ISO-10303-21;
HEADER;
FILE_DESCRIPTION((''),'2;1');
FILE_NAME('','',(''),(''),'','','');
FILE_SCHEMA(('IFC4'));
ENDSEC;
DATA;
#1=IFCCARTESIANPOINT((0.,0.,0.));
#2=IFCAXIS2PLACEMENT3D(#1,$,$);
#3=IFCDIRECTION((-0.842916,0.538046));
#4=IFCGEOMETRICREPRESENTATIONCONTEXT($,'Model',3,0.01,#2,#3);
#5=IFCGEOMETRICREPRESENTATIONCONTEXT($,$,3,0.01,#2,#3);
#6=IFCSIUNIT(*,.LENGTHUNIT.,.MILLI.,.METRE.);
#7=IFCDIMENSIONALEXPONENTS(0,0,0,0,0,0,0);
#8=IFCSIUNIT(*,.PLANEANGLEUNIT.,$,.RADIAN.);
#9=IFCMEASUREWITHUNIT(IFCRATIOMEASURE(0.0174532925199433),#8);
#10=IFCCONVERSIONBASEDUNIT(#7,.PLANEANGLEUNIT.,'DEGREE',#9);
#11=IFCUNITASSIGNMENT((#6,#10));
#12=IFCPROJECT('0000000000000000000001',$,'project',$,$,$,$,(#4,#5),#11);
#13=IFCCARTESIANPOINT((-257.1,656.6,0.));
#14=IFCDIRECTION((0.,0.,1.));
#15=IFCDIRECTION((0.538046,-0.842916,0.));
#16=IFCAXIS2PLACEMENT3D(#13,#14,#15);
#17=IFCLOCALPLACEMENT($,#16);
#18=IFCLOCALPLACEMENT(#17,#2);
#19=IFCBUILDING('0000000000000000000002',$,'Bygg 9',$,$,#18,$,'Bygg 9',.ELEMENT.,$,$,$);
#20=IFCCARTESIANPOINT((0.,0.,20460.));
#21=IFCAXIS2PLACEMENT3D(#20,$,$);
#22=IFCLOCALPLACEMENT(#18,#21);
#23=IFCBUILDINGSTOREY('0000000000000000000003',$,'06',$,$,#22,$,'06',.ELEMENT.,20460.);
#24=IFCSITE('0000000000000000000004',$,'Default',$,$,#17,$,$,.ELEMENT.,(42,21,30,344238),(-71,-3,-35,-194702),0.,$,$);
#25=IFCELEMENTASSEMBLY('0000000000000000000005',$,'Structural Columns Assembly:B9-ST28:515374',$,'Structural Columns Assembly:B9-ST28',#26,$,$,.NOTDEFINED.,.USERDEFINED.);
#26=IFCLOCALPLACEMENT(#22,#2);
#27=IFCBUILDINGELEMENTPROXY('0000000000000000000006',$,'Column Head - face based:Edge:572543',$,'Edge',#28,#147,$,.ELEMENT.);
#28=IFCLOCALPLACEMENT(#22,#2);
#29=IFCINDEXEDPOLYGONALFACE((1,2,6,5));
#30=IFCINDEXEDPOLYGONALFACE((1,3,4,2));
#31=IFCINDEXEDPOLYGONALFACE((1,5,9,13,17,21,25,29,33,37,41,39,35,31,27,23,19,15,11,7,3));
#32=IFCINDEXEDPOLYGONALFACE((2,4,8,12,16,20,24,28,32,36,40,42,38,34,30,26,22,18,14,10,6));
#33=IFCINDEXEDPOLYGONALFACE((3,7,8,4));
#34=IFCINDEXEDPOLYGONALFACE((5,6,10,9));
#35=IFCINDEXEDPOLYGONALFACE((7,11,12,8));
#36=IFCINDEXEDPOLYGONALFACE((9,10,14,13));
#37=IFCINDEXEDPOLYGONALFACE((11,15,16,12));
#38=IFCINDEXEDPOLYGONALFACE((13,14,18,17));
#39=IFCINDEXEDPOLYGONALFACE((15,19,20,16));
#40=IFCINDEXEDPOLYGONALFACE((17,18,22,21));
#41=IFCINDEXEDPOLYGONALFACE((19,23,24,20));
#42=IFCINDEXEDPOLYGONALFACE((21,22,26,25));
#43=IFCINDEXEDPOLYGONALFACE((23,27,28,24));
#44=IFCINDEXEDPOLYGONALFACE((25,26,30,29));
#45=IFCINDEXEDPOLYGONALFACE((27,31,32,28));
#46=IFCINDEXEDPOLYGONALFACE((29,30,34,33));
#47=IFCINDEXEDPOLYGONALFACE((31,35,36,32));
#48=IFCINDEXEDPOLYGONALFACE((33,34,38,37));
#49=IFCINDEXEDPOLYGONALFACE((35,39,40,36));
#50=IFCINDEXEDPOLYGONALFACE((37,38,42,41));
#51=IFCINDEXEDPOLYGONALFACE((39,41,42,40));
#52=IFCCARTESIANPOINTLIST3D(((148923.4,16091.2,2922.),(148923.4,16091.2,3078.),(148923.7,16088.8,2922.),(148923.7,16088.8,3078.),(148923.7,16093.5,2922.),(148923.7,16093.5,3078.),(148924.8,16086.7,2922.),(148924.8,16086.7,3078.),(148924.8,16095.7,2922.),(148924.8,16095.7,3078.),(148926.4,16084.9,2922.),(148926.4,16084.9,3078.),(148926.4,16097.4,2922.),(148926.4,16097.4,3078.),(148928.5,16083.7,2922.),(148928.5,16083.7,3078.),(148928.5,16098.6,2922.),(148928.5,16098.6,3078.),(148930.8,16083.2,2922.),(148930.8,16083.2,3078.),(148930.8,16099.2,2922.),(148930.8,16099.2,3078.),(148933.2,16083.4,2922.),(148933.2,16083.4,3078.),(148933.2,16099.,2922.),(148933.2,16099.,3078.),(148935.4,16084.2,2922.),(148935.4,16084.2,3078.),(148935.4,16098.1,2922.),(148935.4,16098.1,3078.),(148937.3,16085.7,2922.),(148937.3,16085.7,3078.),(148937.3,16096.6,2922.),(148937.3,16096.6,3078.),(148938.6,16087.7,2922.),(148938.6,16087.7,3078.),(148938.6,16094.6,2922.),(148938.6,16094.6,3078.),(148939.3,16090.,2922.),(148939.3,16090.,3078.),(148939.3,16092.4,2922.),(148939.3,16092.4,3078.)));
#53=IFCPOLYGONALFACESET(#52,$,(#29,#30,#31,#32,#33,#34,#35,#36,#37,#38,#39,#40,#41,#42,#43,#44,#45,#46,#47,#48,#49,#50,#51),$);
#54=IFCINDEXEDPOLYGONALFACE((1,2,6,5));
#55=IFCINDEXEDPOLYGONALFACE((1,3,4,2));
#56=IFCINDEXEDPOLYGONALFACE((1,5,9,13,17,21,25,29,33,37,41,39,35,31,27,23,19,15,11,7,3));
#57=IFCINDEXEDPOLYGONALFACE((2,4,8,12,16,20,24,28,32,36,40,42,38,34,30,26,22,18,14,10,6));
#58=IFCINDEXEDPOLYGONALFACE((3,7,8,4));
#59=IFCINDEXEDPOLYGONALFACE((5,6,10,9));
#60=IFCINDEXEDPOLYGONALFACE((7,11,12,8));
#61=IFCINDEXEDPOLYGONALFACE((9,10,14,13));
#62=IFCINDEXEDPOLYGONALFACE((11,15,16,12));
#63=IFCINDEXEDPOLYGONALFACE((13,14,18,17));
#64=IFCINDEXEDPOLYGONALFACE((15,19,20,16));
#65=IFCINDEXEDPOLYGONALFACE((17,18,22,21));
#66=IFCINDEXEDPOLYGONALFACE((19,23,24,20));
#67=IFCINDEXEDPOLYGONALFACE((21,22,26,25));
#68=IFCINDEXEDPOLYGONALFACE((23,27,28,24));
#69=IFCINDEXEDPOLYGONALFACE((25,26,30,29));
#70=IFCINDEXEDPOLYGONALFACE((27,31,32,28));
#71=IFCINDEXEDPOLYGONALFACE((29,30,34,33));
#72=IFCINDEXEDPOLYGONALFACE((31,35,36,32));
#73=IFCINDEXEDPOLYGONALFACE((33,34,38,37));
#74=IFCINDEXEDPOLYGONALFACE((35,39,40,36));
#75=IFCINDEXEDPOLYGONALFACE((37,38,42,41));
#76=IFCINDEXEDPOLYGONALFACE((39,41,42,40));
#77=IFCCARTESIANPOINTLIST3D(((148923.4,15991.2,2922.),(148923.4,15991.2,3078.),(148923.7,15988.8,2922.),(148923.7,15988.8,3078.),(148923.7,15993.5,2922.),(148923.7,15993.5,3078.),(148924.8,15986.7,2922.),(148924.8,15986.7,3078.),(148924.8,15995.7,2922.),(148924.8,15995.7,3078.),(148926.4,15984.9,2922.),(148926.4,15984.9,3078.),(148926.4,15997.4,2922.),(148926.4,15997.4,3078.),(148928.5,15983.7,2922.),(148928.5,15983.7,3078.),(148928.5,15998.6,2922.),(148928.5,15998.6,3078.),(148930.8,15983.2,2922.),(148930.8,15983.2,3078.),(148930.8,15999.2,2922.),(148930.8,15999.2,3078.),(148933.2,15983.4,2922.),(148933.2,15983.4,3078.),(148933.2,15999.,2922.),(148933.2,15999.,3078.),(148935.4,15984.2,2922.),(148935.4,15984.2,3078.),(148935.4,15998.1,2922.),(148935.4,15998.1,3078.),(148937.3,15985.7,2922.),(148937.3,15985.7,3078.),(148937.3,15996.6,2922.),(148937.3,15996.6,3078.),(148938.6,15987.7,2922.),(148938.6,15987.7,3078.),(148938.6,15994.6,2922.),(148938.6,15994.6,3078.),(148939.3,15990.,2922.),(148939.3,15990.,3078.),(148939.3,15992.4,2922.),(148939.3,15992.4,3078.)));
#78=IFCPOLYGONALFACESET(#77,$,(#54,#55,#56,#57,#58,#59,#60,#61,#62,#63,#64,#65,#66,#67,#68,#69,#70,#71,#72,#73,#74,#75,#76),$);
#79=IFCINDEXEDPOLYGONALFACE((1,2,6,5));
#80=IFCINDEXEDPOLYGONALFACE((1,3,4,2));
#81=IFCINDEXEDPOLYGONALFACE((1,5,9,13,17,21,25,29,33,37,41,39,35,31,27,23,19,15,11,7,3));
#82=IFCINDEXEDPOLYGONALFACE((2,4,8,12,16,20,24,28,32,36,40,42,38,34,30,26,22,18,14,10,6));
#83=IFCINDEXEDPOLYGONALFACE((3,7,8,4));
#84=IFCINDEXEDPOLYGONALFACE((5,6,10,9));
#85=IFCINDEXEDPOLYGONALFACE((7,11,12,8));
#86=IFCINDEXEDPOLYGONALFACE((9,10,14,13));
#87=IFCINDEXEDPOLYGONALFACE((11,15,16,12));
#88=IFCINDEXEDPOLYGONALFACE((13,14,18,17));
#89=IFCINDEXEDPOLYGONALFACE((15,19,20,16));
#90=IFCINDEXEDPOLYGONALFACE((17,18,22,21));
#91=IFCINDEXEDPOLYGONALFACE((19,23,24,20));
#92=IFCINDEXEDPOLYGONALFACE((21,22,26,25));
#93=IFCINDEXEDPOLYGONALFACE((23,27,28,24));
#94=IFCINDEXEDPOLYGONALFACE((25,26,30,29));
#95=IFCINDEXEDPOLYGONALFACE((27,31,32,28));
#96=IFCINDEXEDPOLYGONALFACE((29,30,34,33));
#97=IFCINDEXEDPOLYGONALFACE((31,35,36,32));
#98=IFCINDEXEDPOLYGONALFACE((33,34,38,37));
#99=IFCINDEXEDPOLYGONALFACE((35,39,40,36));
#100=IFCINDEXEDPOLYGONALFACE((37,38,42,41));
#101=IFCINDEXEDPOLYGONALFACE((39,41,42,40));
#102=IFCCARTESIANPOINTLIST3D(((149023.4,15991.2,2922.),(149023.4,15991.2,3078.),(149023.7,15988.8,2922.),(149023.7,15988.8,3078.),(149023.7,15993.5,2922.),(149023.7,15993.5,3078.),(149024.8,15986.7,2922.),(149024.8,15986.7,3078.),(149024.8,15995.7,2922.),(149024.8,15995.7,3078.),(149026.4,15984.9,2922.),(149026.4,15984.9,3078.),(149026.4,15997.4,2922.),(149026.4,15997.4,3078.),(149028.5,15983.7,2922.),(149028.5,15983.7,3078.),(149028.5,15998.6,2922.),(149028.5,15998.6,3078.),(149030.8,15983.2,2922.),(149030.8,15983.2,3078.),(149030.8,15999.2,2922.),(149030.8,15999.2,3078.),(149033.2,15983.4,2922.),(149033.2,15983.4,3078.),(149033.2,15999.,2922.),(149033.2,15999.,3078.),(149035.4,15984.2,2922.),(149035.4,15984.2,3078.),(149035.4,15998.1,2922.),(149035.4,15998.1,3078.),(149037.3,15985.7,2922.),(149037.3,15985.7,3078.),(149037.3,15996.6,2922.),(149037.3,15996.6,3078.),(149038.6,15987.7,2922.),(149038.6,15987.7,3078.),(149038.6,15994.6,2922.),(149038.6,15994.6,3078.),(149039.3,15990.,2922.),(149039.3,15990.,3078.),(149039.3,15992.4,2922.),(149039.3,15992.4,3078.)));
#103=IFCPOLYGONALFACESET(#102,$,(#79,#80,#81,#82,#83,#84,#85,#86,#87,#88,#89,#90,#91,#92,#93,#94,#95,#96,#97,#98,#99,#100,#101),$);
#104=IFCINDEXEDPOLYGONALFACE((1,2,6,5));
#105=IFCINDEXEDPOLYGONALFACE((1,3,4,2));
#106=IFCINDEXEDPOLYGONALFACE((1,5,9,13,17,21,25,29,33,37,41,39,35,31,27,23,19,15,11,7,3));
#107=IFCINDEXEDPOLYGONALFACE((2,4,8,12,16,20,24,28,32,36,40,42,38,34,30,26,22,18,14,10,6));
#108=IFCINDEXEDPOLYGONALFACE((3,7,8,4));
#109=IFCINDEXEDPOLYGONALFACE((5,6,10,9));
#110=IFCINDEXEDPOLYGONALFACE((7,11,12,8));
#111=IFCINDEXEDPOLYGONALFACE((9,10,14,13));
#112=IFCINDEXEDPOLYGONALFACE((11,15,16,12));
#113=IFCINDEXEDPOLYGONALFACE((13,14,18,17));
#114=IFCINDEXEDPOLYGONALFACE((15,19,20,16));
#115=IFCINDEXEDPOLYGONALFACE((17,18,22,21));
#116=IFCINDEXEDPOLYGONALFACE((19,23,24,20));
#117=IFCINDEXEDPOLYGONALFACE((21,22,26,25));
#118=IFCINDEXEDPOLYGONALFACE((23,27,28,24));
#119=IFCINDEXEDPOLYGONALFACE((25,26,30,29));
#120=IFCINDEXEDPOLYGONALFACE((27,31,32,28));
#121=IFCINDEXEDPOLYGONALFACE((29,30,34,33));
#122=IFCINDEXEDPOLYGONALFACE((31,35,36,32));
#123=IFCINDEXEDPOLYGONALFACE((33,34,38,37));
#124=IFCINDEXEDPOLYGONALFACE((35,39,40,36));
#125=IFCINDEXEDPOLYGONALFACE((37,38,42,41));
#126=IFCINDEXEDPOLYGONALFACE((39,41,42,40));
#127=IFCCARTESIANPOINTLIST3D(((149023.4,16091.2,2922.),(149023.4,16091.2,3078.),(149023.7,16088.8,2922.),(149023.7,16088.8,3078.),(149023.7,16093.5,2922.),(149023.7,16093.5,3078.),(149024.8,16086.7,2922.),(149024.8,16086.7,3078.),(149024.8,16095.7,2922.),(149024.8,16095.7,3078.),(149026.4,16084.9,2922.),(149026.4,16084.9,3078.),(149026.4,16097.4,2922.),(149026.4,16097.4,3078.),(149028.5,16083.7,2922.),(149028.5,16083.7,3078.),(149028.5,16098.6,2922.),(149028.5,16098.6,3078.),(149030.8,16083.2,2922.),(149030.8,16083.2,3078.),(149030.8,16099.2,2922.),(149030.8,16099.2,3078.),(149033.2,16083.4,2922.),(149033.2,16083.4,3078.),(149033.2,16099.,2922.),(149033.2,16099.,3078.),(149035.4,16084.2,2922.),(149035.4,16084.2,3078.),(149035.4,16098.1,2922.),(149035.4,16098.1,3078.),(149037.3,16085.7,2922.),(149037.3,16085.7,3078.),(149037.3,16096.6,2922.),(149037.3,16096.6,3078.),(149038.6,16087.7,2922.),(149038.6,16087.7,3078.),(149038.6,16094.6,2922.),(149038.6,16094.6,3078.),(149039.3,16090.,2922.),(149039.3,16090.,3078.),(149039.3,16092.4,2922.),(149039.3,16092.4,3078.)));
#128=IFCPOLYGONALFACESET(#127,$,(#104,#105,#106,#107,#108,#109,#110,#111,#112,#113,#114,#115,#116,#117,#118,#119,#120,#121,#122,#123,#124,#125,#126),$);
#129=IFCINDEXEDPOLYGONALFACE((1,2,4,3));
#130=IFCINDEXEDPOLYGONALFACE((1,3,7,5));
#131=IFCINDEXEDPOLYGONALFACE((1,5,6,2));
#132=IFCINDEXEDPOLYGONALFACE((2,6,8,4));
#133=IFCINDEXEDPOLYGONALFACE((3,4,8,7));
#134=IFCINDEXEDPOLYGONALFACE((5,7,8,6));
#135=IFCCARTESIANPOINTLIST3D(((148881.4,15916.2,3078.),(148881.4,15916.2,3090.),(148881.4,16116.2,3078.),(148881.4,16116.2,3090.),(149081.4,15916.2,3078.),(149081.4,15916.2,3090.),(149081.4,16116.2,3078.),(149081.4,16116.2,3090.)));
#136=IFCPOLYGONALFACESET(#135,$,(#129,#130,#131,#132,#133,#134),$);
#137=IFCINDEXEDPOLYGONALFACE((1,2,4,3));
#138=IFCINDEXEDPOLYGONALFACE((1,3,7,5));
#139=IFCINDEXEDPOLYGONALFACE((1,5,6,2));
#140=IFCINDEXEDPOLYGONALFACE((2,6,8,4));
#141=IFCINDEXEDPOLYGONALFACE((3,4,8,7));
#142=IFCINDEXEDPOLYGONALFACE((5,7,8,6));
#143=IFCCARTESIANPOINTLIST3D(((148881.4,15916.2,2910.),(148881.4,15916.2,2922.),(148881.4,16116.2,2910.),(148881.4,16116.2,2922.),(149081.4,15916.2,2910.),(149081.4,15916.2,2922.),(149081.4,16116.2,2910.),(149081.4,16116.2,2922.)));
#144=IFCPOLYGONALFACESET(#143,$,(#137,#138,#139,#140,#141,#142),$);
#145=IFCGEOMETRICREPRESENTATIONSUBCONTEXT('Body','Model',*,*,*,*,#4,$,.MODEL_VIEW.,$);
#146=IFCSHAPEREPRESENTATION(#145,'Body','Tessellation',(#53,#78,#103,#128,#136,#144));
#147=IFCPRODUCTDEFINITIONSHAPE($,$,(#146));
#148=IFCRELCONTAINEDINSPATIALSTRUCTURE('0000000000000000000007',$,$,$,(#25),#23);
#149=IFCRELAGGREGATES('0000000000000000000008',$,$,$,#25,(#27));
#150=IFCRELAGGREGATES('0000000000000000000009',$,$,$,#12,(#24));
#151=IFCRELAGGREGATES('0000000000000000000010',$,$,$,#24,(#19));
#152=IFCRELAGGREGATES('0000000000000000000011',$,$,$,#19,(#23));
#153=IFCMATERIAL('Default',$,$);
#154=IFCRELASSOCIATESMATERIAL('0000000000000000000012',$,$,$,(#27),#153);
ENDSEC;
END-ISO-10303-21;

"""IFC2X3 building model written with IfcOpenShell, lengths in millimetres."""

from ifc_helpers import new_model, entity, si_unit, converted_unit, direction, frame, frame_2d, origin, origin_2d_with_axis, place, context, subcontext, project, spatial, rectangle, circle, extrude, source, transform, mapped, material, element, aggregate, save


model = new_model("IFC2X3")

# Units and contexts
model_context = context("Model", 3, precision=0.01, world=origin(), true_north=direction((-0.842916, 0.538046)))
context_of_model = context(None, 3, precision=0.01, world=origin(), true_north=direction((-0.842916, 0.538046)))
body_context = subcontext(model_context, "Body", "Model", "MODEL_VIEW")
ifc_project = project(units=[si_unit("LENGTHUNIT", "METRE", prefix="MILLI"), converted_unit("PLANEANGLEUNIT", "DEGREE", entity("IfcRatioMeasure", 0.0174532925199433), si_unit("PLANEANGLEUNIT", "RADIAN"), dimensions=[0, 0, 0, 0, 0, 0, 0])], contexts=[model_context, context_of_model])

# Site, building, storey
site_placement = place(None, frame((-257.1, 656.6, 0.0), z_axis=(0.0, 0.0, 1.0), x_axis=(0.538046, -0.842916, 0.0)))
site = spatial("IfcSite", under=ifc_project, at=site_placement, Name="Default", CompositionType="ELEMENT", RefLatitude=(42, 21, 30, 344238), RefLongitude=(-71, -3, -35, -194702), RefElevation=0.0)
building_placement = place(site_placement, origin())
building = spatial("IfcBuilding", under=site, at=building_placement, Name="Bygg 9", LongName="Bygg 9", CompositionType="ELEMENT")
storey_placement = place(building_placement, frame((0.0, 0.0, 20460.0)))
storey = spatial("IfcBuildingStorey", under=building, at=storey_placement, Name="06", LongName="06", CompositionType="ELEMENT", Elevation=20460.0)

# Element assembly
assembly_1_placement = place(storey_placement, origin())
assembly_1 = element("IfcElementAssembly", 1, at=assembly_1_placement, inside=storey, Name="Structural Columns Assembly:B9-ST28:515374", ObjectType="Structural Columns Assembly:B9-ST28", AssemblyPlace="NOTDEFINED", PredefinedType="USERDEFINED")

# Shared definitions
ifc_material_1 = material(Name="Default")

# Building element proxy
shared_shape_1 = source(origin(), body_context, "Body", "SweptSolid", [
    extrude(circle(Radius=8.0, at=frame_2d((0.0, 0.0), x_axis=(1.0, 0.0))), frame((50.0, -75.0, 12.0)), (0.0, 0.0, 1.0), 156.0),
    extrude(circle(Radius=8.0, at=frame_2d((0.0, 0.0), x_axis=(1.0, 0.0))), frame((50.0, 25.0, 12.0)), (0.0, 0.0, 1.0), 156.0),
    extrude(circle(Radius=8.0, at=frame_2d((0.0, 0.0), x_axis=(1.0, 0.0))), frame((-50.0, 25.0, 12.0)), (0.0, 0.0, 1.0), 156.0),
    extrude(circle(Radius=8.0, at=frame_2d((0.0, 0.0), x_axis=(1.0, 0.0))), frame((-50.0, -75.0, 12.0)), (0.0, 0.0, 1.0), 156.0),
    extrude(rectangle(XDim=200.0, YDim=200.0, at=origin_2d_with_axis()), frame((0.0, 0.0, 168.0), z_axis=(0.0, 0.0, 1.0), x_axis=(-1.0, 0.0, 0.0)), (0.0, 0.0, 1.0), 12.0),
    extrude(rectangle(XDim=200.0, YDim=200.0, at=origin_2d_with_axis()), frame((0.0, 0.0, 0.0), z_axis=(0.0, 0.0, 1.0), x_axis=(0.0, 1.0, 0.0)), (0.0, 0.0, 1.0), 12.0),
])
proxy_1_placement = place(assembly_1_placement, frame((148981.4, 16016.2, 2910.0), z_axis=(0.0, 0.0, 1.0), x_axis=(-1.0, 0.0, 0.0)))
proxy_1 = element("IfcBuildingElementProxy", 2, at=proxy_1_placement, material=ifc_material_1, Name="Column Head - face based:Edge:572543", ObjectType="Edge", CompositionType="ELEMENT", context=body_context, shape_type="MappedRepresentation", body=[
    mapped(shared_shape_1, transform((0.0, 0.0, 0.0), scale=1.0)),
])
aggregate(assembly_1, [proxy_1])

save(model, "model.ifc")
